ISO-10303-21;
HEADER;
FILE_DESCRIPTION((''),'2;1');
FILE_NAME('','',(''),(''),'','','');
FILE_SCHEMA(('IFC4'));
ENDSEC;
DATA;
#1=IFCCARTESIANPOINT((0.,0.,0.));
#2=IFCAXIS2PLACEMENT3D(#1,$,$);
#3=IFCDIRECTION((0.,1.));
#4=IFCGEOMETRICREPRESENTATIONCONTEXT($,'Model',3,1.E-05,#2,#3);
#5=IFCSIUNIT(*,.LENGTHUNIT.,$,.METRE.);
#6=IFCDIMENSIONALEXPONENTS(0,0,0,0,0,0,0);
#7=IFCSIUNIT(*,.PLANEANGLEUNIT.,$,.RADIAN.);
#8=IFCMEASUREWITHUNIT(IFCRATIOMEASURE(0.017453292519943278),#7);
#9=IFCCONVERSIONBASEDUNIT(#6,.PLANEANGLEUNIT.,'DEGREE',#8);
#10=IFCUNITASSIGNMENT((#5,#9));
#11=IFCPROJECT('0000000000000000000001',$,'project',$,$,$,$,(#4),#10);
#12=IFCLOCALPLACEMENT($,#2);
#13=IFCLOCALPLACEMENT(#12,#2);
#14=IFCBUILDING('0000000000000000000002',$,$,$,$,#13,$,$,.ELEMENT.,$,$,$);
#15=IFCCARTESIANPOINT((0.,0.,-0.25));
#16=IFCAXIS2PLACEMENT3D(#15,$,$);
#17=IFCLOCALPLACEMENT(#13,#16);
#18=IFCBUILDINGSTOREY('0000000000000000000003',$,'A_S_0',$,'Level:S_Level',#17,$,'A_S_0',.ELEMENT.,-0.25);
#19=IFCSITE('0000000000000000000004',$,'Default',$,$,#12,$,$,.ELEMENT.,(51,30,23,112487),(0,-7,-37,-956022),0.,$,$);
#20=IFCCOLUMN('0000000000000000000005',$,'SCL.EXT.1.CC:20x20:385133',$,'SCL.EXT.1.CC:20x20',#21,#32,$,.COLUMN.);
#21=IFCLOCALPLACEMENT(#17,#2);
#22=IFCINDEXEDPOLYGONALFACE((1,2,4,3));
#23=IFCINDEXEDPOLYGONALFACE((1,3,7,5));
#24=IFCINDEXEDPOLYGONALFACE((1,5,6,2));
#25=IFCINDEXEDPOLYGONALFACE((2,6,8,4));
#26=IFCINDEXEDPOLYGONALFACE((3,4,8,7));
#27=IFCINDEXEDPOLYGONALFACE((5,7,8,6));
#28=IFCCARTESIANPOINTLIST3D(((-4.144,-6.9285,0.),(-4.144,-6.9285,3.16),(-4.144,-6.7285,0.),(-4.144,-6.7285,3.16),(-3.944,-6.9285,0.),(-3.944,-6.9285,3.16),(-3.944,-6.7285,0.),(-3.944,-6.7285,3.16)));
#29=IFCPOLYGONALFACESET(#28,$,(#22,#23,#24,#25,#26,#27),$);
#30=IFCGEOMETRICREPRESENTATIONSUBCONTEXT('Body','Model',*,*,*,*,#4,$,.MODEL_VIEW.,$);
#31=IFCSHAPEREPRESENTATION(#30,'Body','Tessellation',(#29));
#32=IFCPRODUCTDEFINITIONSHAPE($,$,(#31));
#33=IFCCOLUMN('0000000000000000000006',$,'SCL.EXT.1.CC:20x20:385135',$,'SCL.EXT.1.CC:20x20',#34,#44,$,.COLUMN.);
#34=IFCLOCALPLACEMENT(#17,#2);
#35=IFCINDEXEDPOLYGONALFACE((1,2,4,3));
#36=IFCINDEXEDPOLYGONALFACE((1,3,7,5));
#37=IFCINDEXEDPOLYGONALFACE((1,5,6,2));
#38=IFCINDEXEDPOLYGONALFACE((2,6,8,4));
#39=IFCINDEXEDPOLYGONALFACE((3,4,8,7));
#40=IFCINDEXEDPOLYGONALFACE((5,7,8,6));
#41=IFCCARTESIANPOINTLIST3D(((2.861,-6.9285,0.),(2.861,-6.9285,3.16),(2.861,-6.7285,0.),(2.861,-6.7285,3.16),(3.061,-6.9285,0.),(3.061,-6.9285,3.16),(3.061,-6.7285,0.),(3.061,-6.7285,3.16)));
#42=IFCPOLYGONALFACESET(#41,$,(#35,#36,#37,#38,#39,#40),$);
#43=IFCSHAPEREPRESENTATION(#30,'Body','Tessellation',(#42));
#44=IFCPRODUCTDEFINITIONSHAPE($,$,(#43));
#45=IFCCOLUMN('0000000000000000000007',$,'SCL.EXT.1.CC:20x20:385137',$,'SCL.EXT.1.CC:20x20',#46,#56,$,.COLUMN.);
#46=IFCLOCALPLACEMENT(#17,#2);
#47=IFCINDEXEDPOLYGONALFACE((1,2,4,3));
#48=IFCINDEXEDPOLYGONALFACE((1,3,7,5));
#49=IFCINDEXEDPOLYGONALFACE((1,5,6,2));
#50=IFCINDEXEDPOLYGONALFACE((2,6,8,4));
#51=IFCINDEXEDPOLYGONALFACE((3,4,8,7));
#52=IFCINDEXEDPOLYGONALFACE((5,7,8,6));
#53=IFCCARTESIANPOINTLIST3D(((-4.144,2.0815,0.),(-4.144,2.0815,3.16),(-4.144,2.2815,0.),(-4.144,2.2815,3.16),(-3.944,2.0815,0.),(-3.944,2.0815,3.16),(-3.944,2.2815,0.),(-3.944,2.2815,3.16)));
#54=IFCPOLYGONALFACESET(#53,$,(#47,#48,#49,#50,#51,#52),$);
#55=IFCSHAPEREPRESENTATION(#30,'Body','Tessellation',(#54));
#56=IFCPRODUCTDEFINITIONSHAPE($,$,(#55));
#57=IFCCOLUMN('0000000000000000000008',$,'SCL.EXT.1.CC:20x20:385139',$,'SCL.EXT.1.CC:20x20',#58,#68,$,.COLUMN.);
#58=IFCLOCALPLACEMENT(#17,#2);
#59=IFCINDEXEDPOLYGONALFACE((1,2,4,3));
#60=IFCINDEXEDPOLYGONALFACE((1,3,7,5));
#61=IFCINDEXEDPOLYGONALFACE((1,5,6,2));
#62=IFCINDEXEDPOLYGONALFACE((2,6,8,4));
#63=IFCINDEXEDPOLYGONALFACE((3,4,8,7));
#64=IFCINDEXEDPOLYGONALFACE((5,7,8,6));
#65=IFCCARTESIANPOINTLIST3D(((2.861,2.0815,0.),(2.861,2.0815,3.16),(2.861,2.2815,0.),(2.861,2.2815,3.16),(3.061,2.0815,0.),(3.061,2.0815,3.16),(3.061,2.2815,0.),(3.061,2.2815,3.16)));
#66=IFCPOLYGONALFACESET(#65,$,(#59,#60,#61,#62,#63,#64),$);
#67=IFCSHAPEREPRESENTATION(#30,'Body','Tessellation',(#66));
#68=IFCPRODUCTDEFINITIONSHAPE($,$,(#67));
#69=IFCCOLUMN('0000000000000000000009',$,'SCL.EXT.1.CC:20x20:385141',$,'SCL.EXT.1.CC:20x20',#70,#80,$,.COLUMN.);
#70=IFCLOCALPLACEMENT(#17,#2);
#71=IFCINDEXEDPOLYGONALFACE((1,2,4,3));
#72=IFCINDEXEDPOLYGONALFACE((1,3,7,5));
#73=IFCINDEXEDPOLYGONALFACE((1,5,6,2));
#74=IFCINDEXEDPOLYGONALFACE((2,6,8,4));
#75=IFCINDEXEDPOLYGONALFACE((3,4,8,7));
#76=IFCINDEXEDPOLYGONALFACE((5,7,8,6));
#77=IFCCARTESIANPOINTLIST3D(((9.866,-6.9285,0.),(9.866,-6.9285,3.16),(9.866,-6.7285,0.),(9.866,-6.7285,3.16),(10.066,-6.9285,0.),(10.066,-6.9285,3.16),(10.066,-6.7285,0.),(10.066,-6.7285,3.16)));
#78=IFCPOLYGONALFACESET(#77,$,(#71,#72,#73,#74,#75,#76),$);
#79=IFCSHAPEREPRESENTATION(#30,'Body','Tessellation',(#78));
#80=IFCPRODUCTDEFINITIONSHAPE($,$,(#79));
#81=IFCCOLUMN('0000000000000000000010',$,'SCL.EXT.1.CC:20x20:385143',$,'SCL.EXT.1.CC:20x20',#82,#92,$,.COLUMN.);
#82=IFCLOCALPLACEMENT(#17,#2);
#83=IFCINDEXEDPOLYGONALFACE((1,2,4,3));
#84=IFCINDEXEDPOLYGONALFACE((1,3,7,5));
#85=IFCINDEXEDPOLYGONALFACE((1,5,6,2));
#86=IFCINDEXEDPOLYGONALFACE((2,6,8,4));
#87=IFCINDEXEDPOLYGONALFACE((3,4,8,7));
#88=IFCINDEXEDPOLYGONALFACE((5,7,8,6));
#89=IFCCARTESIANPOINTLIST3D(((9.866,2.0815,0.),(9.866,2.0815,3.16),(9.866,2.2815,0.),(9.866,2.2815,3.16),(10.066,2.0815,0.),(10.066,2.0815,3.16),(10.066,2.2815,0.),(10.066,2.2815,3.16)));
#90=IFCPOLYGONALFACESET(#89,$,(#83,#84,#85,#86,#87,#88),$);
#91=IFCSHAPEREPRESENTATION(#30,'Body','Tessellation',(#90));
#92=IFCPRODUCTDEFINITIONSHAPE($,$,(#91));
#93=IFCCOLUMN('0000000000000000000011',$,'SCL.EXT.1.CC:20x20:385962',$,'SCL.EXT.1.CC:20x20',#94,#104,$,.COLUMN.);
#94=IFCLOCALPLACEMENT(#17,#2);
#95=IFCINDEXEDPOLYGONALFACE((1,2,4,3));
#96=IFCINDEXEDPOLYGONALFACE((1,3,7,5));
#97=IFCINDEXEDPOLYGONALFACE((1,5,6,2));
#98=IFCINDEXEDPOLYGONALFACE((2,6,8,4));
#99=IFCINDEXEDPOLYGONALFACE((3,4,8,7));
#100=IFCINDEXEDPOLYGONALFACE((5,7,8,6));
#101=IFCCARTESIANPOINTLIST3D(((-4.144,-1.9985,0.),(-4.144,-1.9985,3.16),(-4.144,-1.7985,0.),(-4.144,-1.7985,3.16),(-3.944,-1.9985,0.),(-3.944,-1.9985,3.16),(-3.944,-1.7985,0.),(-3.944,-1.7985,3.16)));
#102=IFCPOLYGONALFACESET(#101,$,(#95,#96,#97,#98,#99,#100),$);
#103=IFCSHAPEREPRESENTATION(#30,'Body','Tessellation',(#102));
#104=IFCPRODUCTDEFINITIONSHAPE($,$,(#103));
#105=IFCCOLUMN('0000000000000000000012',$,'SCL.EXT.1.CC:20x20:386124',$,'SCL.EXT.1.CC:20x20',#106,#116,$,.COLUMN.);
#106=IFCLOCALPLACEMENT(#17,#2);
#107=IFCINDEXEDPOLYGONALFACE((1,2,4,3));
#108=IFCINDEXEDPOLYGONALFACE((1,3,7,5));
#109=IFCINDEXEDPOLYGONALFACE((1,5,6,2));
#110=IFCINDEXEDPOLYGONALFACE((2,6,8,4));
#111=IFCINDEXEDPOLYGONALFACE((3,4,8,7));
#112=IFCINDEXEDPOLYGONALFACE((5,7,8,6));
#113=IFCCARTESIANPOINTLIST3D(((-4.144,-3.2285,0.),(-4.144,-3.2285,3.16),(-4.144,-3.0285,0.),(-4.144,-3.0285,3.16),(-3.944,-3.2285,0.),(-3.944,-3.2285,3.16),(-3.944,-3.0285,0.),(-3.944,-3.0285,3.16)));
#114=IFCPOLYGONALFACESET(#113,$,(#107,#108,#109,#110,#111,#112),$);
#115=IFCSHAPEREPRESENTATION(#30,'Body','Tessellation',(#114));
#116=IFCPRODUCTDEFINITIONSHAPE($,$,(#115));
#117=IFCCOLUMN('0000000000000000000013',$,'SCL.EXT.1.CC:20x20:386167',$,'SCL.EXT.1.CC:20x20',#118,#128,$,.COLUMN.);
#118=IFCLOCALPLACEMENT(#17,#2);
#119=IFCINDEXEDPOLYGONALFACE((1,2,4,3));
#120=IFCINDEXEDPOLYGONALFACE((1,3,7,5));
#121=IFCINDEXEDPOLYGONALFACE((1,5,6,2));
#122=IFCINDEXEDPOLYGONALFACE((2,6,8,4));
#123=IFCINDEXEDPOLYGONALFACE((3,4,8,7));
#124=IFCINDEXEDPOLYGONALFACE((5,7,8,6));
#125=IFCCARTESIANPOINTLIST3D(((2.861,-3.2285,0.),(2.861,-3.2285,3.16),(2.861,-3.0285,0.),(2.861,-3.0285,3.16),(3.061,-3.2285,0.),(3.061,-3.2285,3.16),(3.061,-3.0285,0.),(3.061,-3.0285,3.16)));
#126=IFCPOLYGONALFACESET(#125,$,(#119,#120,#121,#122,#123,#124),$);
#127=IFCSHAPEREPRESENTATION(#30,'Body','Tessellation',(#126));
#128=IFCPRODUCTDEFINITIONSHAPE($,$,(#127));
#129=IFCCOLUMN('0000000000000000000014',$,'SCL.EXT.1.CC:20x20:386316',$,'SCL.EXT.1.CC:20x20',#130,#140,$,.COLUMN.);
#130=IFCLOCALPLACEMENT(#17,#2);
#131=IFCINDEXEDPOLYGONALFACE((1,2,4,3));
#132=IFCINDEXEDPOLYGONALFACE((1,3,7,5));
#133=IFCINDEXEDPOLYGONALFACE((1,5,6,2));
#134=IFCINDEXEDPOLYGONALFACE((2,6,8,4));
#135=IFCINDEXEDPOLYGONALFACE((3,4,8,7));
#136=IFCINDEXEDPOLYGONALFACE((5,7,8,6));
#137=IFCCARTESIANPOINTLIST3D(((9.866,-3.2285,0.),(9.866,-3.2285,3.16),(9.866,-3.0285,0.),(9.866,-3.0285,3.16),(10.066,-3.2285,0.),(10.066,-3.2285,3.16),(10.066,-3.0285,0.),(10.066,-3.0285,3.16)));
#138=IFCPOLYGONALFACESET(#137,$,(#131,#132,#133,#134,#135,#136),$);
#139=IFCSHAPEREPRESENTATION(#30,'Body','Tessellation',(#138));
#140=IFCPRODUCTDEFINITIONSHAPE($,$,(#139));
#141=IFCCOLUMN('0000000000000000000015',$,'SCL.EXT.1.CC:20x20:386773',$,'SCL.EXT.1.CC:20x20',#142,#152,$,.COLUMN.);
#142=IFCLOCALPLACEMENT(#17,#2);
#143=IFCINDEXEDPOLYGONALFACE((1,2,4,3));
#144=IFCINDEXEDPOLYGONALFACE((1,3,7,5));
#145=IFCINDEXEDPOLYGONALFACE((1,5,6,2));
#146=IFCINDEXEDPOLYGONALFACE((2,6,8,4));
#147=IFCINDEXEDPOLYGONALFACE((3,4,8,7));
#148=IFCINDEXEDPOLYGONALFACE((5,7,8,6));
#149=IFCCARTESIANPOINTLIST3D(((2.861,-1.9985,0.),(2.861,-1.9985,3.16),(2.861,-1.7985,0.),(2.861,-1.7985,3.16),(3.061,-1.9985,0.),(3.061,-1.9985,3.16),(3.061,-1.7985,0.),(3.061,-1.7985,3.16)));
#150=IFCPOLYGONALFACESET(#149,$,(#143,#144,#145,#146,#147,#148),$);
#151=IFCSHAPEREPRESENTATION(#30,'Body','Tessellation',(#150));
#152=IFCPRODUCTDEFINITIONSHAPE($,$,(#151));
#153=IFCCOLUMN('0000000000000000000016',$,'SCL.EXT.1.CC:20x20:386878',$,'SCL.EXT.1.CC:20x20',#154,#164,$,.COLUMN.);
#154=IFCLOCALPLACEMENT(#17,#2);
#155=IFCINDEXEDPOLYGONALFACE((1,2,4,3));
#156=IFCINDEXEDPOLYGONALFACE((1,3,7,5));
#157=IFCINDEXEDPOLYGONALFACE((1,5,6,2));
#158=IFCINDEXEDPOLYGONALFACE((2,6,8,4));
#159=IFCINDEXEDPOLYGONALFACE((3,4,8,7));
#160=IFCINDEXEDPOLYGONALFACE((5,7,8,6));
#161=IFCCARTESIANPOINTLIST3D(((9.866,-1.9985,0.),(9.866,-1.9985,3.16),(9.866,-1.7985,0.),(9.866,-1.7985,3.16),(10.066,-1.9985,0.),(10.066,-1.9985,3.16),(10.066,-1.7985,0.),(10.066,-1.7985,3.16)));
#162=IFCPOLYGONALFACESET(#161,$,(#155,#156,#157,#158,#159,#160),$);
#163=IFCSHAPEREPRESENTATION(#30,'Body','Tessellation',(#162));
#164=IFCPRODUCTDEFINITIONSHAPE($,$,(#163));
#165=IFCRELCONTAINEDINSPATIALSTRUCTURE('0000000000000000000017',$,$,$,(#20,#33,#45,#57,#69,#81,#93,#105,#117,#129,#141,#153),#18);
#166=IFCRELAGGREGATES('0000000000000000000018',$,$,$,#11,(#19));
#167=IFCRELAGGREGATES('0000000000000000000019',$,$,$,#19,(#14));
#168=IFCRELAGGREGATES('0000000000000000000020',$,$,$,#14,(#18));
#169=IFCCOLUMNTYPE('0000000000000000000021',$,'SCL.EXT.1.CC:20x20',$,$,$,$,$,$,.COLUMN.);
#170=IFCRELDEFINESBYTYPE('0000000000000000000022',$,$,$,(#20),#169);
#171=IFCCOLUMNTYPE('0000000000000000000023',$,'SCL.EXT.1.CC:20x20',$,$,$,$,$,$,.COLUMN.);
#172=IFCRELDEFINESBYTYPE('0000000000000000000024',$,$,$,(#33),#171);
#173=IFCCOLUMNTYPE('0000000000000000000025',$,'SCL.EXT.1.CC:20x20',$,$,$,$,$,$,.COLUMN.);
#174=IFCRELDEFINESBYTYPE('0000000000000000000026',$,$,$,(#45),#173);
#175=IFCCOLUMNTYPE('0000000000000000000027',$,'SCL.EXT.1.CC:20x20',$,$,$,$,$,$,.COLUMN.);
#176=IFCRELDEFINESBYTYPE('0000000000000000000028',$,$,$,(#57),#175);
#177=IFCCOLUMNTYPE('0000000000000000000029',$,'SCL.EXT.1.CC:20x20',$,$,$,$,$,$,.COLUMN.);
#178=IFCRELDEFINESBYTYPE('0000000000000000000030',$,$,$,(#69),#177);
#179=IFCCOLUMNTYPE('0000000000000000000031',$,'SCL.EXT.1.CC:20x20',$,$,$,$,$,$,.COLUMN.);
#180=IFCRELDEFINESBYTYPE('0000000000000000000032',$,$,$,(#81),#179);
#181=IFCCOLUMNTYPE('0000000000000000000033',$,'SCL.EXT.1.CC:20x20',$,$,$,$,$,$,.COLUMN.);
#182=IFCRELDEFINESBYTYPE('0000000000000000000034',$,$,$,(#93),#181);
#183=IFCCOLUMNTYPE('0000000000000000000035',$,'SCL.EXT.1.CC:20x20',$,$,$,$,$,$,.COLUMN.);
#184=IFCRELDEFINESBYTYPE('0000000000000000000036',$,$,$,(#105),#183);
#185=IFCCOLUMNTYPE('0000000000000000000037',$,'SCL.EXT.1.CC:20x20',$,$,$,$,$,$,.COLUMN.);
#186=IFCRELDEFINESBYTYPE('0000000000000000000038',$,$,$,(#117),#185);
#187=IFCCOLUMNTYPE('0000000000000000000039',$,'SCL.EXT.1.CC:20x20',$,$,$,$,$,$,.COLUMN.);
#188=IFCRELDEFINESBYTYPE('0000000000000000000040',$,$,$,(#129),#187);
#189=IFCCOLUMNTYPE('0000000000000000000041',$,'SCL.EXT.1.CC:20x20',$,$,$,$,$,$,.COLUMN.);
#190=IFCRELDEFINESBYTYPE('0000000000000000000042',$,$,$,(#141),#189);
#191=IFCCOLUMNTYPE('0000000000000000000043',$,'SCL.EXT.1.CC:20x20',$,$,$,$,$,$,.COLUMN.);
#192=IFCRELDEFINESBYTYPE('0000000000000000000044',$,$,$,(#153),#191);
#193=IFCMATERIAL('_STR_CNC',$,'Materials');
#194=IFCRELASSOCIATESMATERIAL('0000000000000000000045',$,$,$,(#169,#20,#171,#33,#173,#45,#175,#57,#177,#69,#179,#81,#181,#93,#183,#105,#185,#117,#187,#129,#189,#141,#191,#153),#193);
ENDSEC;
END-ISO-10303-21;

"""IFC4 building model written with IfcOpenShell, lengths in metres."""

from ifc_helpers import new_model, entity, si_unit, converted_unit, direction, frame, origin, place, context, subcontext, project, spatial, indexed_curve, outline, extrude, source, transform, mapped, material, type_object, type_shapes, element, save


model = new_model("IFC4")

# Units and contexts
model_context = context("Model", 3, precision=1e-05, world=origin(), true_north=direction((0.0, 1.0)))
body_context = subcontext(model_context, "Body", "Model", "MODEL_VIEW")
ifc_project = project(units=[si_unit("LENGTHUNIT", "METRE"), converted_unit("PLANEANGLEUNIT", "DEGREE", entity("IfcRatioMeasure", 0.017453292519943278), si_unit("PLANEANGLEUNIT", "RADIAN"), dimensions=[0, 0, 0, 0, 0, 0, 0])], contexts=[model_context])

# Site, building, storey
site_placement = place(None, origin())
site = spatial("IfcSite", under=ifc_project, at=site_placement, Name="Default", CompositionType="ELEMENT", RefLatitude=(51, 30, 23, 112487), RefLongitude=(0, -7, -37, -956022), RefElevation=0.0)
building_placement = place(site_placement, origin())
building = spatial("IfcBuilding", under=site, at=building_placement, CompositionType="ELEMENT")
storey_placement = place(building_placement, frame((0.0, 0.0, -0.25)))
storey = spatial("IfcBuildingStorey", under=building, at=storey_placement, Name="A_S_0", ObjectType="Level:S_Level", LongName="A_S_0", CompositionType="ELEMENT", Elevation=-0.25)

# Columns
ifc_material_1 = material(Name="_STR_CNC", Category="Materials")
column_type_1 = type_object("IfcColumnType", Name="SCL.EXT.1.CC:20x20", PredefinedType="COLUMN", material=ifc_material_1)
shared_shape_1 = source(origin(), body_context, "Body", "SweptSolid", [
    extrude(outline(indexed_curve([(-0.1, -0.1), (0.1, -0.1), (0.1, 0.1), (-0.1, 0.1), (-0.1, -0.1)], self_intersect=False)), frame((-4.044, -6.8285, -0.25), z_axis=(0.0, 0.0, 1.0), x_axis=(0.0, -1.0, 0.0)), (0.0, 0.0, 1.0), 3.16),
])
type_shapes(column_type_1, [shared_shape_1])
column_1_placement = place(storey_placement, frame((0.0, 0.0, 0.25)))
element("IfcColumn", 1, at=column_1_placement, inside=storey, type_object=column_type_1, material=ifc_material_1, Name="SCL.EXT.1.CC:20x20:385133", ObjectType="SCL.EXT.1.CC:20x20", PredefinedType="COLUMN", context=body_context, shape_type="MappedRepresentation", body=[
    mapped(shared_shape_1, transform((0.0, 0.0, 0.0), scale=1.0)),
])
column_type_2 = type_object("IfcColumnType", Name="SCL.EXT.1.CC:20x20", PredefinedType="COLUMN", material=ifc_material_1)
shared_shape_2 = source(origin(), body_context, "Body", "SweptSolid", [
    extrude(outline(indexed_curve([(-0.1, -0.1), (0.1, -0.1), (0.1, 0.1), (-0.1, 0.1), (-0.1, -0.1)], self_intersect=False)), frame((2.961, -6.8285, -0.25), z_axis=(0.0, 0.0, 1.0), x_axis=(0.0, -1.0, 0.0)), (0.0, 0.0, 1.0), 3.16),
])
type_shapes(column_type_2, [shared_shape_2])
column_2_placement = place(storey_placement, frame((0.0, 0.0, 0.25)))
element("IfcColumn", 2, at=column_2_placement, inside=storey, type_object=column_type_2, material=ifc_material_1, Name="SCL.EXT.1.CC:20x20:385135", ObjectType="SCL.EXT.1.CC:20x20", PredefinedType="COLUMN", context=body_context, shape_type="MappedRepresentation", body=[
    mapped(shared_shape_2, transform((0.0, 0.0, 0.0), scale=1.0)),
])
column_type_3 = type_object("IfcColumnType", Name="SCL.EXT.1.CC:20x20", PredefinedType="COLUMN", material=ifc_material_1)
shared_shape_3 = source(origin(), body_context, "Body", "SweptSolid", [
    extrude(outline(indexed_curve([(-0.1, -0.1), (0.1, -0.1), (0.1, 0.1), (-0.1, 0.1), (-0.1, -0.1)], self_intersect=False)), frame((-4.044, 2.1815, -0.25), z_axis=(0.0, 0.0, 1.0), x_axis=(0.0, -1.0, 0.0)), (0.0, 0.0, 1.0), 3.16),
])
type_shapes(column_type_3, [shared_shape_3])
column_3_placement = place(storey_placement, frame((0.0, 0.0, 0.25)))
element("IfcColumn", 3, at=column_3_placement, inside=storey, type_object=column_type_3, material=ifc_material_1, Name="SCL.EXT.1.CC:20x20:385137", ObjectType="SCL.EXT.1.CC:20x20", PredefinedType="COLUMN", context=body_context, shape_type="MappedRepresentation", body=[
    mapped(shared_shape_3, transform((0.0, 0.0, 0.0), scale=1.0)),
])
column_type_4 = type_object("IfcColumnType", Name="SCL.EXT.1.CC:20x20", PredefinedType="COLUMN", material=ifc_material_1)
shared_shape_4 = source(origin(), body_context, "Body", "SweptSolid", [
    extrude(outline(indexed_curve([(-0.1, -0.1), (0.1, -0.1), (0.1, 0.1), (-0.1, 0.1), (-0.1, -0.1)], self_intersect=False)), frame((2.961, 2.1815, -0.25), z_axis=(0.0, 0.0, 1.0), x_axis=(0.0, -1.0, 0.0)), (0.0, 0.0, 1.0), 3.16),
])
type_shapes(column_type_4, [shared_shape_4])
column_4_placement = place(storey_placement, frame((0.0, 0.0, 0.25)))
element("IfcColumn", 4, at=column_4_placement, inside=storey, type_object=column_type_4, material=ifc_material_1, Name="SCL.EXT.1.CC:20x20:385139", ObjectType="SCL.EXT.1.CC:20x20", PredefinedType="COLUMN", context=body_context, shape_type="MappedRepresentation", body=[
    mapped(shared_shape_4, transform((0.0, 0.0, 0.0), scale=1.0)),
])
column_type_5 = type_object("IfcColumnType", Name="SCL.EXT.1.CC:20x20", PredefinedType="COLUMN", material=ifc_material_1)
shared_shape_5 = source(origin(), body_context, "Body", "SweptSolid", [
    extrude(outline(indexed_curve([(-0.1, -0.1), (0.1, -0.1), (0.1, 0.1), (-0.1, 0.1), (-0.1, -0.1)], self_intersect=False)), frame((9.966, -6.8285, -0.25), z_axis=(0.0, 0.0, 1.0), x_axis=(0.0, -1.0, 0.0)), (0.0, 0.0, 1.0), 3.16),
])
type_shapes(column_type_5, [shared_shape_5])
column_5_placement = place(storey_placement, frame((0.0, 0.0, 0.25)))
element("IfcColumn", 5, at=column_5_placement, inside=storey, type_object=column_type_5, material=ifc_material_1, Name="SCL.EXT.1.CC:20x20:385141", ObjectType="SCL.EXT.1.CC:20x20", PredefinedType="COLUMN", context=body_context, shape_type="MappedRepresentation", body=[
    mapped(shared_shape_5, transform((0.0, 0.0, 0.0), scale=1.0)),
])
column_type_6 = type_object("IfcColumnType", Name="SCL.EXT.1.CC:20x20", PredefinedType="COLUMN", material=ifc_material_1)
shared_shape_6 = source(origin(), body_context, "Body", "SweptSolid", [
    extrude(outline(indexed_curve([(-0.1, -0.1), (0.1, -0.1), (0.1, 0.1), (-0.1, 0.1), (-0.1, -0.1)], self_intersect=False)), frame((9.966, 2.1815, -0.25), z_axis=(0.0, 0.0, 1.0), x_axis=(0.0, -1.0, 0.0)), (0.0, 0.0, 1.0), 3.16),
])
type_shapes(column_type_6, [shared_shape_6])
column_6_placement = place(storey_placement, frame((0.0, 0.0, 0.25)))
element("IfcColumn", 6, at=column_6_placement, inside=storey, type_object=column_type_6, material=ifc_material_1, Name="SCL.EXT.1.CC:20x20:385143", ObjectType="SCL.EXT.1.CC:20x20", PredefinedType="COLUMN", context=body_context, shape_type="MappedRepresentation", body=[
    mapped(shared_shape_6, transform((0.0, 0.0, 0.0), scale=1.0)),
])
column_type_7 = type_object("IfcColumnType", Name="SCL.EXT.1.CC:20x20", PredefinedType="COLUMN", material=ifc_material_1)
shared_shape_7 = source(origin(), body_context, "Body", "SweptSolid", [
    extrude(outline(indexed_curve([(-0.1, -0.1), (0.1, -0.1), (0.1, 0.1), (-0.1, 0.1), (-0.1, -0.1)], self_intersect=False)), frame((-4.044, -1.8985, -0.25), z_axis=(0.0, 0.0, 1.0), x_axis=(0.0, -1.0, 0.0)), (0.0, 0.0, 1.0), 3.16),
])
type_shapes(column_type_7, [shared_shape_7])
column_7_placement = place(storey_placement, frame((0.0, 0.0, 0.25)))
element("IfcColumn", 7, at=column_7_placement, inside=storey, type_object=column_type_7, material=ifc_material_1, Name="SCL.EXT.1.CC:20x20:385962", ObjectType="SCL.EXT.1.CC:20x20", PredefinedType="COLUMN", context=body_context, shape_type="MappedRepresentation", body=[
    mapped(shared_shape_7, transform((0.0, 0.0, 0.0), scale=1.0)),
])
column_type_8 = type_object("IfcColumnType", Name="SCL.EXT.1.CC:20x20", PredefinedType="COLUMN", material=ifc_material_1)
shared_shape_8 = source(origin(), body_context, "Body", "SweptSolid", [
    extrude(outline(indexed_curve([(-0.1, -0.1), (0.1, -0.1), (0.1, 0.1), (-0.1, 0.1), (-0.1, -0.1)], self_intersect=False)), frame((-4.044, -3.1285, -0.25), z_axis=(0.0, 0.0, 1.0), x_axis=(0.0, -1.0, 0.0)), (0.0, 0.0, 1.0), 3.16),
])
type_shapes(column_type_8, [shared_shape_8])
column_8_placement = place(storey_placement, frame((0.0, 0.0, 0.25)))
element("IfcColumn", 8, at=column_8_placement, inside=storey, type_object=column_type_8, material=ifc_material_1, Name="SCL.EXT.1.CC:20x20:386124", ObjectType="SCL.EXT.1.CC:20x20", PredefinedType="COLUMN", context=body_context, shape_type="MappedRepresentation", body=[
    mapped(shared_shape_8, transform((0.0, 0.0, 0.0), scale=1.0)),
])
column_type_9 = type_object("IfcColumnType", Name="SCL.EXT.1.CC:20x20", PredefinedType="COLUMN", material=ifc_material_1)
shared_shape_9 = source(origin(), body_context, "Body", "SweptSolid", [
    extrude(outline(indexed_curve([(-0.1, -0.1), (0.1, -0.1), (0.1, 0.1), (-0.1, 0.1), (-0.1, -0.1)], self_intersect=False)), frame((2.961, -3.1285, -0.25), z_axis=(0.0, 0.0, 1.0), x_axis=(0.0, -1.0, 0.0)), (0.0, 0.0, 1.0), 3.16),
])
type_shapes(column_type_9, [shared_shape_9])
column_9_placement = place(storey_placement, frame((0.0, 0.0, 0.25)))
element("IfcColumn", 9, at=column_9_placement, inside=storey, type_object=column_type_9, material=ifc_material_1, Name="SCL.EXT.1.CC:20x20:386167", ObjectType="SCL.EXT.1.CC:20x20", PredefinedType="COLUMN", context=body_context, shape_type="MappedRepresentation", body=[
    mapped(shared_shape_9, transform((0.0, 0.0, 0.0), scale=1.0)),
])
column_type_10 = type_object("IfcColumnType", Name="SCL.EXT.1.CC:20x20", PredefinedType="COLUMN", material=ifc_material_1)
shared_shape_10 = source(origin(), body_context, "Body", "SweptSolid", [
    extrude(outline(indexed_curve([(-0.1, -0.1), (0.1, -0.1), (0.1, 0.1), (-0.1, 0.1), (-0.1, -0.1)], self_intersect=False)), frame((9.966, -3.1285, -0.25), z_axis=(0.0, 0.0, 1.0), x_axis=(0.0, -1.0, 0.0)), (0.0, 0.0, 1.0), 3.16),
])
type_shapes(column_type_10, [shared_shape_10])
column_10_placement = place(storey_placement, frame((0.0, 0.0, 0.25)))
element("IfcColumn", 10, at=column_10_placement, inside=storey, type_object=column_type_10, material=ifc_material_1, Name="SCL.EXT.1.CC:20x20:386316", ObjectType="SCL.EXT.1.CC:20x20", PredefinedType="COLUMN", context=body_context, shape_type="MappedRepresentation", body=[
    mapped(shared_shape_10, transform((0.0, 0.0, 0.0), scale=1.0)),
])
column_type_11 = type_object("IfcColumnType", Name="SCL.EXT.1.CC:20x20", PredefinedType="COLUMN", material=ifc_material_1)
shared_shape_11 = source(origin(), body_context, "Body", "SweptSolid", [
    extrude(outline(indexed_curve([(-0.1, -0.1), (0.1, -0.1), (0.1, 0.1), (-0.1, 0.1), (-0.1, -0.1)], self_intersect=False)), frame((2.961, -1.8985, -0.25), z_axis=(0.0, 0.0, 1.0), x_axis=(0.0, -1.0, 0.0)), (0.0, 0.0, 1.0), 3.16),
])
type_shapes(column_type_11, [shared_shape_11])
column_11_placement = place(storey_placement, frame((0.0, 0.0, 0.25)))
element("IfcColumn", 11, at=column_11_placement, inside=storey, type_object=column_type_11, material=ifc_material_1, Name="SCL.EXT.1.CC:20x20:386773", ObjectType="SCL.EXT.1.CC:20x20", PredefinedType="COLUMN", context=body_context, shape_type="MappedRepresentation", body=[
    mapped(shared_shape_11, transform((0.0, 0.0, 0.0), scale=1.0)),
])
column_type_12 = type_object("IfcColumnType", Name="SCL.EXT.1.CC:20x20", PredefinedType="COLUMN", material=ifc_material_1)
shared_shape_12 = source(origin(), body_context, "Body", "SweptSolid", [
    extrude(outline(indexed_curve([(-0.1, -0.1), (0.1, -0.1), (0.1, 0.1), (-0.1, 0.1), (-0.1, -0.1)], self_intersect=False)), frame((9.966, -1.8985, -0.25), z_axis=(0.0, 0.0, 1.0), x_axis=(0.0, -1.0, 0.0)), (0.0, 0.0, 1.0), 3.16),
])
type_shapes(column_type_12, [shared_shape_12])
column_12_placement = place(storey_placement, frame((0.0, 0.0, 0.25)))
element("IfcColumn", 12, at=column_12_placement, inside=storey, type_object=column_type_12, material=ifc_material_1, Name="SCL.EXT.1.CC:20x20:386878", ObjectType="SCL.EXT.1.CC:20x20", PredefinedType="COLUMN", context=body_context, shape_type="MappedRepresentation", body=[
    mapped(shared_shape_12, transform((0.0, 0.0, 0.0), scale=1.0)),
])

save(model, "model.ifc")
